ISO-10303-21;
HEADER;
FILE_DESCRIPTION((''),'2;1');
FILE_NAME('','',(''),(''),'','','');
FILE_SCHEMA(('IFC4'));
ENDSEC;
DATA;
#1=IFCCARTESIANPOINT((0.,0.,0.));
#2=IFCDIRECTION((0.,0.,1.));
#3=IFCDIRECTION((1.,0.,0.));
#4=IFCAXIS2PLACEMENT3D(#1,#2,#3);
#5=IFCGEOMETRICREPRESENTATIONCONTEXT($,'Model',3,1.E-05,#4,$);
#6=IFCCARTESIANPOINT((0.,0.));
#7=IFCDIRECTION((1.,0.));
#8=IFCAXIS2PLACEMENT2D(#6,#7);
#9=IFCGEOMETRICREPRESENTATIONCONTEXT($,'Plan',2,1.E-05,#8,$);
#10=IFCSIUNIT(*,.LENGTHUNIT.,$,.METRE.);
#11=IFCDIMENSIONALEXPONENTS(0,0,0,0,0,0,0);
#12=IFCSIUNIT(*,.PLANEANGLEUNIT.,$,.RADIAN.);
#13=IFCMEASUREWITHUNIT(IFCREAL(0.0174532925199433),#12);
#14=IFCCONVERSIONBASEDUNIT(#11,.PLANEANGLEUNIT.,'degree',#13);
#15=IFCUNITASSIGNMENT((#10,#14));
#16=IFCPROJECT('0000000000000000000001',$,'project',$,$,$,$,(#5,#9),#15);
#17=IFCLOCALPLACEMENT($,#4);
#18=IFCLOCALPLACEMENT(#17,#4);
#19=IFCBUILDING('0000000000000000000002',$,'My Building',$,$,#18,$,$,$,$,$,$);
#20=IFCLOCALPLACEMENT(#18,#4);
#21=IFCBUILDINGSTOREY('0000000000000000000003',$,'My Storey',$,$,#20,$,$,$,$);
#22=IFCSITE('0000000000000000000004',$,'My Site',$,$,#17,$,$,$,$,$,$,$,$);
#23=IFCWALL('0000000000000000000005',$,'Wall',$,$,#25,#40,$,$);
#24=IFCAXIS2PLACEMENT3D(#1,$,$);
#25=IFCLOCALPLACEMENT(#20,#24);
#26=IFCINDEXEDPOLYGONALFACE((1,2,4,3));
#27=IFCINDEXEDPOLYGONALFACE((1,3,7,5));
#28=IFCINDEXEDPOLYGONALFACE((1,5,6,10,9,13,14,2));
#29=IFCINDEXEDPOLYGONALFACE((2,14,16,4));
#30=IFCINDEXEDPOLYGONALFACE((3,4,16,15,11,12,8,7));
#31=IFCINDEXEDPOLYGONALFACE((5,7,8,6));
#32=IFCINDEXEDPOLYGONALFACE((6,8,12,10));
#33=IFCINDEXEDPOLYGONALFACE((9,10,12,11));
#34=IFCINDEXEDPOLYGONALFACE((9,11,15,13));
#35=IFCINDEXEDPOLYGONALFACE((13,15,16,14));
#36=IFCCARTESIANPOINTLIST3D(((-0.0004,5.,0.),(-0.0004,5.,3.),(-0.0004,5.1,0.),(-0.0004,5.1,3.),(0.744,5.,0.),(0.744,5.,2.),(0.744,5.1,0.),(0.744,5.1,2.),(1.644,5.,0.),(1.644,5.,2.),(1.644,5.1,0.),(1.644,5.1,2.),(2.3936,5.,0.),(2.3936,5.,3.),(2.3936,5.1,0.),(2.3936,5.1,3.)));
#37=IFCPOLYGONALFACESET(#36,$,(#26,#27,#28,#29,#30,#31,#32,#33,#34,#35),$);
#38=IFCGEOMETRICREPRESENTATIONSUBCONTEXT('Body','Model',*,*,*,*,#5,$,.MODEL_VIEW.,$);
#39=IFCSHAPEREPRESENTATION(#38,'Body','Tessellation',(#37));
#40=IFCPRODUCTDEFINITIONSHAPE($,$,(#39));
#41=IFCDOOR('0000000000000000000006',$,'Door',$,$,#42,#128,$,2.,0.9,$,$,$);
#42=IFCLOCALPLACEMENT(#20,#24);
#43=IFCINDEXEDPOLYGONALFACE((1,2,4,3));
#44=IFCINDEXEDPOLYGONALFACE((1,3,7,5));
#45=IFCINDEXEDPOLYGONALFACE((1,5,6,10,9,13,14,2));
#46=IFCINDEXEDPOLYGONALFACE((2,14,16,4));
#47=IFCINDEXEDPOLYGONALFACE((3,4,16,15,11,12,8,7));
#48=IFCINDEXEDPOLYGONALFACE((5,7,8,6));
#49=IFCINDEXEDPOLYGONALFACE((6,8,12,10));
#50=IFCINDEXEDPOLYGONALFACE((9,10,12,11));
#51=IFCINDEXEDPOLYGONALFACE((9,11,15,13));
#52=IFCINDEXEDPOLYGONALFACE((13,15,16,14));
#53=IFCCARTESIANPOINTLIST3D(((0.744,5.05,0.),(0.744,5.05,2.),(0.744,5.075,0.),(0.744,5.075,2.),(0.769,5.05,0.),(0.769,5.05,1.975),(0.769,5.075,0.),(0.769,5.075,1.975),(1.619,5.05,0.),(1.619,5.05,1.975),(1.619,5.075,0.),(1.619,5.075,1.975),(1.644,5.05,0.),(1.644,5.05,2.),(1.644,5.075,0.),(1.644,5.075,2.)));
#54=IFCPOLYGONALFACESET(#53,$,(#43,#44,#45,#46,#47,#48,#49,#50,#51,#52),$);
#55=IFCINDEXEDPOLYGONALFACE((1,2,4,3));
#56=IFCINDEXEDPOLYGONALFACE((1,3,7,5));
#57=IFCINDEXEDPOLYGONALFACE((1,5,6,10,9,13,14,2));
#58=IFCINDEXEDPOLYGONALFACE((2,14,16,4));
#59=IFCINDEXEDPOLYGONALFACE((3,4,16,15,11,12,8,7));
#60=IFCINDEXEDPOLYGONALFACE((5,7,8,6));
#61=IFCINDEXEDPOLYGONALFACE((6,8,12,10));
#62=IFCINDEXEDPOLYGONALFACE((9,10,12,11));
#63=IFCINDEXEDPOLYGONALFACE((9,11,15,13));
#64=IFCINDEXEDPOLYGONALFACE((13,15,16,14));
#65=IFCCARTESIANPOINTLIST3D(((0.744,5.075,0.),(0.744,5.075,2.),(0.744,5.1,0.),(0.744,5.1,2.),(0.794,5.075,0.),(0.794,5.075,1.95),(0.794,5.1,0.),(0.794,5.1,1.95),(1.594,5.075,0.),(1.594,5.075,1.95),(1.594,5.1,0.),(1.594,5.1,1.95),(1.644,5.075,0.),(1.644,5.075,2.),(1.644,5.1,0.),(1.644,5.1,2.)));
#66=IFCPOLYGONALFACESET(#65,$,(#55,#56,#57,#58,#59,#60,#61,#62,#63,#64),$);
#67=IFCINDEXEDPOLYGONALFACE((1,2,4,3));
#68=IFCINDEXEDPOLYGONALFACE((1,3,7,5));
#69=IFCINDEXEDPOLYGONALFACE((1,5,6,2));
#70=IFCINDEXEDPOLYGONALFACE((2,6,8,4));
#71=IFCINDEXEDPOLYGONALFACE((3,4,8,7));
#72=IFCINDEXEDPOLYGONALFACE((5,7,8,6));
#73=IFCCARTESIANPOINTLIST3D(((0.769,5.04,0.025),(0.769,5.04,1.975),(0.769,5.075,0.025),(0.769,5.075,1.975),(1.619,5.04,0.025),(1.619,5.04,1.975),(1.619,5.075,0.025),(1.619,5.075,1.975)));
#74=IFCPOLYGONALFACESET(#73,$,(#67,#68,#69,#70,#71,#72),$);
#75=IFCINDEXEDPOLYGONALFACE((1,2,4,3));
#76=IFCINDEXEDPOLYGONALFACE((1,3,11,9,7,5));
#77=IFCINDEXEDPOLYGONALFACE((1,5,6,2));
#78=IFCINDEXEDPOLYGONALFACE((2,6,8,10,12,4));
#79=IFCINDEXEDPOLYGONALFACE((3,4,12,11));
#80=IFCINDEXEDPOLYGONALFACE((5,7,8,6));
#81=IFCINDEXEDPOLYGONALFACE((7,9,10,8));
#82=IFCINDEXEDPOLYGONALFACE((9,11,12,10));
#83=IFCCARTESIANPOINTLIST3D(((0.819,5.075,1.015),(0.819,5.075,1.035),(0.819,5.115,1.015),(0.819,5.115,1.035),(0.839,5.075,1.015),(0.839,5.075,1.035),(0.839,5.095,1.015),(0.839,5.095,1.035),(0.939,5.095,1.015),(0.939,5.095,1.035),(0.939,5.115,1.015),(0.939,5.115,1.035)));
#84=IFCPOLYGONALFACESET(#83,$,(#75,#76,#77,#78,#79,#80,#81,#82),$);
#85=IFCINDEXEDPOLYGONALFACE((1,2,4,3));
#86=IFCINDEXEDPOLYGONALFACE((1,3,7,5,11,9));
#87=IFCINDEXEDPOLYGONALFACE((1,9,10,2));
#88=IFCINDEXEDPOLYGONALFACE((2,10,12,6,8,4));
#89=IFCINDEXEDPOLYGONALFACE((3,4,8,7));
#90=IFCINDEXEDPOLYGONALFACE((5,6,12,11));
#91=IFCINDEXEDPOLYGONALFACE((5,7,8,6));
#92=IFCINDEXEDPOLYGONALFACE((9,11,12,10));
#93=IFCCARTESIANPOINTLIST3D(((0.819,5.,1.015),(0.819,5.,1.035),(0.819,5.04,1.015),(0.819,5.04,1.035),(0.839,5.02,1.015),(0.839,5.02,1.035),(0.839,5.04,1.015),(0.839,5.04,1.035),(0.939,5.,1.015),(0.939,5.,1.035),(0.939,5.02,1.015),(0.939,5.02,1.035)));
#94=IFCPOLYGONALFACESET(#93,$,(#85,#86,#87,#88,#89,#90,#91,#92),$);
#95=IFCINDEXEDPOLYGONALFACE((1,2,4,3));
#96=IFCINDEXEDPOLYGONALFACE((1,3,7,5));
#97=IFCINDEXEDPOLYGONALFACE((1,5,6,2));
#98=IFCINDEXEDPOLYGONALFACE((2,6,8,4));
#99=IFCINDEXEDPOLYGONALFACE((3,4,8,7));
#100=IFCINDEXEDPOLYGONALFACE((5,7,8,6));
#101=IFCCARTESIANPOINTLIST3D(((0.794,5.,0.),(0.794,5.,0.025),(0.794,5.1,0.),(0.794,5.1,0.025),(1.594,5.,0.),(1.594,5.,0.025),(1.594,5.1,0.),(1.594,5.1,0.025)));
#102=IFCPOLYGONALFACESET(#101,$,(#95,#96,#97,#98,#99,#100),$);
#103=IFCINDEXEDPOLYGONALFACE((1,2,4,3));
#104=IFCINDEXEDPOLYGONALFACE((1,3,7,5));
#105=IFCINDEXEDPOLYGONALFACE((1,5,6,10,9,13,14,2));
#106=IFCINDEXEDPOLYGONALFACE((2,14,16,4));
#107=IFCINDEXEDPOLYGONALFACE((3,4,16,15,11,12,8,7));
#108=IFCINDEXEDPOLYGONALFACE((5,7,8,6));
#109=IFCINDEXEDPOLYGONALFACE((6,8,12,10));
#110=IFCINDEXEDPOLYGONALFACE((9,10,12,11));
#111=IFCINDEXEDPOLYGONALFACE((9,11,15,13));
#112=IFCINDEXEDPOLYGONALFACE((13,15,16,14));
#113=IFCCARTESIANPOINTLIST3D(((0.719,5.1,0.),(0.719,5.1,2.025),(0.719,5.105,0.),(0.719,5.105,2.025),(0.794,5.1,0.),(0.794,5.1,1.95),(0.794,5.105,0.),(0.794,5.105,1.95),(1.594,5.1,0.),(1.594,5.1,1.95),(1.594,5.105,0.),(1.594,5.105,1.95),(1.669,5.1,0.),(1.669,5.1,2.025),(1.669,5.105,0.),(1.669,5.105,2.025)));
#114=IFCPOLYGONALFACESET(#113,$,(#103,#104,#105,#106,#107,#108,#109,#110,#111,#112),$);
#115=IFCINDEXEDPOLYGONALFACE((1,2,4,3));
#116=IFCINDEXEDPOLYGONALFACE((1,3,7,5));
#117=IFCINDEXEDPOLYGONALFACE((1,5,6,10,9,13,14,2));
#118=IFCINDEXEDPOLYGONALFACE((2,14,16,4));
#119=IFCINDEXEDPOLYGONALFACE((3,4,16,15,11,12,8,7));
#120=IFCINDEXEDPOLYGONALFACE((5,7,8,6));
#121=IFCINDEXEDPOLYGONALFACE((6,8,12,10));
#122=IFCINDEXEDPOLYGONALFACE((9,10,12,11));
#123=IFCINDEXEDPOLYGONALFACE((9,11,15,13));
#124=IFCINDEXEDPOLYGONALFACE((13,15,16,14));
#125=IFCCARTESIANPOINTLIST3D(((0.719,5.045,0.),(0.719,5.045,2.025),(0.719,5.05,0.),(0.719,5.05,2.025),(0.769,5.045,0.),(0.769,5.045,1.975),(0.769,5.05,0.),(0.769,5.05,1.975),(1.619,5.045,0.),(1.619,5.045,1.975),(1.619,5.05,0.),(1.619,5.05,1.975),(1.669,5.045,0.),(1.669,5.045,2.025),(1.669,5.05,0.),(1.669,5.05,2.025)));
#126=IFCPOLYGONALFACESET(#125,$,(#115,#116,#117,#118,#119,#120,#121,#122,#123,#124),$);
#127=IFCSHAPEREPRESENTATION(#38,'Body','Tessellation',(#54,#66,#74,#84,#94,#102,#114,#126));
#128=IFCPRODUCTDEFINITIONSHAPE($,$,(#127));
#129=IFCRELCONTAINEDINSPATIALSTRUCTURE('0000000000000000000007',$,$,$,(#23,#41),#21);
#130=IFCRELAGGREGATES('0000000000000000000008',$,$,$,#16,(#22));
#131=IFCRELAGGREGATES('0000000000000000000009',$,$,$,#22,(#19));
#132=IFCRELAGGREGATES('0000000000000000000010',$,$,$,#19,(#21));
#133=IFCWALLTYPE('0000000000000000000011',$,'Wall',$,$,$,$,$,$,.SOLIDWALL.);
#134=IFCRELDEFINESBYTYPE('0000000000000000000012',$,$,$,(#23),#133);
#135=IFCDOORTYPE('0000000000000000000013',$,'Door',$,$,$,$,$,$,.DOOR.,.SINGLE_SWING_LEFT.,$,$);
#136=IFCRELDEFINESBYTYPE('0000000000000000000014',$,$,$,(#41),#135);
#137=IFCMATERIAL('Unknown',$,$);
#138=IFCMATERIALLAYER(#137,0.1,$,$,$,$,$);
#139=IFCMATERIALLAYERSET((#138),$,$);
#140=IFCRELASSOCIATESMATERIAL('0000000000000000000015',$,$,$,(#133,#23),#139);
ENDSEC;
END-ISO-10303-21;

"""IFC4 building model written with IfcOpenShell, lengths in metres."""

from ifc_helpers import new_model, entity, si_unit, converted_unit, frame, origin_with_axes, origin_2d_with_axis, place, context, subcontext, project, spatial, line, indexed_curve, outline, extrude, shape, source, transform, mapped, material, layer, layer_set, layer_usage, type_object, type_shapes, element, fill, save


model = new_model("IFC4")

# Units and contexts
model_context = context("Model", 3, precision=1e-05, world=origin_with_axes())
plan_context = context("Plan", 2, precision=1e-05, world=origin_2d_with_axis())
body_context_1 = subcontext(model_context, "Body", "Model", "MODEL_VIEW")
body_context_2 = subcontext(plan_context, "Body", "Plan", "PLAN_VIEW")
ifc_project = project(units=[si_unit("LENGTHUNIT", "METRE"), converted_unit("PLANEANGLEUNIT", "degree", entity("IfcReal", 0.0174532925199433), si_unit("PLANEANGLEUNIT", "RADIAN"), dimensions=[0, 0, 0, 0, 0, 0, 0])], contexts=[model_context, plan_context])

# Site, building, storey
site_placement = place(None, origin_with_axes())
site = spatial("IfcSite", under=ifc_project, at=site_placement, Name="My Site")
building_placement = place(site_placement, origin_with_axes())
building = spatial("IfcBuilding", under=site, at=building_placement, Name="My Building")
storey_placement = place(building_placement, origin_with_axes())
storey = spatial("IfcBuildingStorey", under=building, at=storey_placement, Name="My Storey")

# Shared definitions
ifc_material = material(Name="Unknown")

# Shared definitions
ifc_layer_1 = layer(ifc_material, 0.1)
ifc_layer_set_1 = layer_set([ifc_layer_1])
wall_type = type_object("IfcWallType", Name="Wall", PredefinedType="SOLIDWALL", material=ifc_layer_set_1)
shared_shape_1 = source(origin_with_axes(), body_context_1, "Body", "SweptSolid", [
    extrude(outline(indexed_curve([(0.0, 0.0), (0.9, 0.0), (0.9, 2.0), (0.0, 2.0)], segments=[line(1, 2, 3, 4, 1)])), frame((0.0, -0.6, 0.0), z_axis=(0.0, -1.0, 0.0), x_axis=(1.0, 0.0, 0.0)), (0.0, 0.0, -1.0), 1.2),
])
door_type = type_object("IfcDoorType", Name="Door", OperationType="SINGLE_SWING_LEFT", PredefinedType="DOOR")
shared_shape_2 = source(origin_with_axes(), body_context_1, "Body", "SweptSolid", [
    extrude(outline(indexed_curve([(0.0, 0.0), (0.0, 2.0), (0.9, 2.0), (0.9, 0.0), (0.875, 0.0), (0.875, 1.975), (0.025, 1.975), (0.025, 0.0)], segments=[line(1, 2, 3, 4, 5, 6, 7, 8, 1)])), frame((0.0, 0.025, 0.0), z_axis=(0.0, -1.0, 0.0), x_axis=(1.0, 0.0, 0.0)), (0.0, 0.0, -1.0), 0.025),
    extrude(outline(indexed_curve([(0.0, 0.0), (0.0, 2.0), (0.9, 2.0), (0.9, 0.0), (0.85, 0.0), (0.85, 1.95), (0.05, 1.95), (0.05, 0.0)], segments=[line(1, 2, 3, 4, 5, 6, 7, 8, 1)])), frame((0.0, 0.0, 0.0), z_axis=(0.0, -1.0, 0.0), x_axis=(1.0, 0.0, 0.0)), (0.0, 0.0, -1.0), 0.025),
    extrude(outline(indexed_curve([(0.0, 0.0), (0.85, 0.0), (0.85, 0.035), (0.0, 0.035)], segments=[line(1, 2, 3, 4, 1)])), frame((0.025, 0.025, 0.025), z_axis=(0.0, 0.0, 1.0), x_axis=(1.0, 0.0, 0.0)), (0.0, 0.0, 1.0), 1.95),
    extrude(outline(indexed_curve([(0.0, 0.0), (0.0, -0.04), (-0.12, -0.04), (-0.12, -0.02), (-0.02, -0.02), (-0.02, 0.0)], segments=[line(1, 2, 3, 4, 5, 6, 1)])), frame((0.825, 0.025, 1.015), z_axis=(0.0, 0.0, 1.0), x_axis=(1.0, 0.0, 0.0)), (0.0, 0.0, 1.0), 0.02),
    extrude(outline(indexed_curve([(0.0, 0.0), (0.0, 0.04), (-0.12, 0.04), (-0.12, 0.02), (-0.02, 0.02), (-0.02, 0.0)], segments=[line(1, 2, 3, 4, 5, 6, 1)])), frame((0.825, 0.06, 1.015), z_axis=(0.0, 0.0, 1.0), x_axis=(1.0, 0.0, 0.0)), (0.0, 0.0, 1.0), 0.02),
    extrude(outline(indexed_curve([(0.0, 0.0), (0.8, 0.0), (0.8, 0.1), (0.0, 0.1)], segments=[line(1, 2, 3, 4, 1)])), frame((0.05, 0.0, 0.0), z_axis=(0.0, 0.0, 1.0), x_axis=(1.0, 0.0, 0.0)), (0.0, 0.0, 1.0), 0.025),
    extrude(outline(indexed_curve([(0.0, 0.0), (0.0, 2.025), (0.95, 2.025), (0.95, 0.0), (0.875, 0.0), (0.875, 1.95), (0.075, 1.95), (0.075, 0.0)], segments=[line(1, 2, 3, 4, 5, 6, 7, 8, 1)])), frame((-0.025, -0.005, 0.0), z_axis=(0.0, -1.0, 0.0), x_axis=(1.0, 0.0, 0.0)), (0.0, 0.0, -1.0), 0.005),
    extrude(outline(indexed_curve([(0.0, 0.0), (0.0, 2.025), (0.95, 2.025), (0.95, 0.0), (0.9, 0.0), (0.9, 1.975), (0.05, 1.975), (0.05, 0.0)], segments=[line(1, 2, 3, 4, 5, 6, 7, 8, 1)])), frame((-0.025, 0.05, 0.0), z_axis=(0.0, -1.0, 0.0), x_axis=(1.0, 0.0, 0.0)), (0.0, 0.0, -1.0), 0.005),
])
shared_shape_3 = source(origin_with_axes(), body_context_2, "Body", "Curve2D", [
    entity("IfcIndexedPolyCurve", entity("IfcCartesianPointList2D", [[0.0, 0.0], [0.0, 0.05], [0.025, 0.05], [0.025, 0.025], [0.05, 0.025], [0.05, 0.0]]), [entity("IfcLineIndex", [1, 2, 3, 4, 5, 6, 1])]),
    entity("IfcIndexedPolyCurve", entity("IfcCartesianPointList2D", [[0.9, 0.0], [0.9, 0.05], [0.875, 0.05], [0.875, 0.025], [0.85, 0.025], [0.85, 0.0]]), [entity("IfcLineIndex", [1, 2, 3, 4, 5, 6, 1])]),
    entity("IfcTrimmedCurve", entity("IfcEllipse", entity("IfcAxis2Placement2D", entity("IfcCartesianPoint", [0.06, 0.05]), entity("IfcDirection", [1.0, 0.0])), 0.815, 0.85), [entity("IfcCartesianPoint", [0.875, 0.05])], [entity("IfcCartesianPoint", [0.06, 0.9])], True, "CARTESIAN"),
    entity("IfcIndexedPolyCurve", entity("IfcCartesianPointList2D", [[0.025, 0.05], [0.06, 0.05], [0.06, 0.9], [0.025, 0.9]]), [entity("IfcLineIndex", [1, 2, 3, 4, 1])]),
])
type_shapes(door_type, [shared_shape_2, shared_shape_3])

# Wall, opening, door
ifc_layer_usage_1 = layer_usage(ifc_layer_set_1, "AXIS2", "POSITIVE", 0.0)
wall_1_placement = place(storey_placement, frame((2.3936, 5.1, 0.0), z_axis=(0.0, 0.0, 1.0), x_axis=(-1.0, 0.0, 0.0)))
wall_1 = element("IfcWall", 1, at=wall_1_placement, inside=storey, type_object=wall_type, material=ifc_layer_usage_1, Name="Wall", context=body_context_1, shape_type="SweptSolid", body=[
    extrude(outline(indexed_curve([(0.0, 0.0), (0.0, 0.1), (2.394, 0.1), (2.394, 0.0)], segments=[line(1, 2, 3, 4, 1)])), origin_with_axes(), (0.0, 0.0, 1.0), 3.0),
])
opening_1_placement = place(wall_1_placement, frame((0.7496, 0.0, 0.0), z_axis=(0.0, 0.0, 1.0), x_axis=(1.0, 0.0, 0.0)))
opening_1 = element("IfcOpeningElement", 2, at=opening_1_placement, cuts=wall_1, PredefinedType="OPENING", context=body_context_1, shape_type="MappedRepresentation", body=[
    mapped(shared_shape_1, transform((0.0, 0.0, 0.0), x_axis=(1.0, 0.0, 0.0), y_axis=(0.0, 1.0, 0.0), z_axis=(0.0, 0.0, 1.0), scale=1.0)),
])
door_1_placement = place(opening_1_placement, origin_with_axes())
door_1 = element("IfcDoor", 3, at=door_1_placement, inside=storey, type_object=door_type, Name="Door", OverallHeight=2.0, OverallWidth=0.9, shapes=[
    shape(body_context_1, "Body", "MappedRepresentation", [mapped(shared_shape_2, transform((0.0, 0.0, 0.0), x_axis=(1.0, 0.0, 0.0), y_axis=(0.0, 1.0, 0.0), z_axis=(0.0, 0.0, 1.0), scale=1.0))]),
    shape(body_context_2, "Body", "MappedRepresentation", [mapped(shared_shape_3, transform((0.0, 0.0, 0.0), x_axis=(1.0, 0.0, 0.0), y_axis=(0.0, 1.0, 0.0), z_axis=(0.0, 0.0, 1.0), scale=1.0))]),
])
fill(opening_1, door_1)

save(model, "model.ifc")
